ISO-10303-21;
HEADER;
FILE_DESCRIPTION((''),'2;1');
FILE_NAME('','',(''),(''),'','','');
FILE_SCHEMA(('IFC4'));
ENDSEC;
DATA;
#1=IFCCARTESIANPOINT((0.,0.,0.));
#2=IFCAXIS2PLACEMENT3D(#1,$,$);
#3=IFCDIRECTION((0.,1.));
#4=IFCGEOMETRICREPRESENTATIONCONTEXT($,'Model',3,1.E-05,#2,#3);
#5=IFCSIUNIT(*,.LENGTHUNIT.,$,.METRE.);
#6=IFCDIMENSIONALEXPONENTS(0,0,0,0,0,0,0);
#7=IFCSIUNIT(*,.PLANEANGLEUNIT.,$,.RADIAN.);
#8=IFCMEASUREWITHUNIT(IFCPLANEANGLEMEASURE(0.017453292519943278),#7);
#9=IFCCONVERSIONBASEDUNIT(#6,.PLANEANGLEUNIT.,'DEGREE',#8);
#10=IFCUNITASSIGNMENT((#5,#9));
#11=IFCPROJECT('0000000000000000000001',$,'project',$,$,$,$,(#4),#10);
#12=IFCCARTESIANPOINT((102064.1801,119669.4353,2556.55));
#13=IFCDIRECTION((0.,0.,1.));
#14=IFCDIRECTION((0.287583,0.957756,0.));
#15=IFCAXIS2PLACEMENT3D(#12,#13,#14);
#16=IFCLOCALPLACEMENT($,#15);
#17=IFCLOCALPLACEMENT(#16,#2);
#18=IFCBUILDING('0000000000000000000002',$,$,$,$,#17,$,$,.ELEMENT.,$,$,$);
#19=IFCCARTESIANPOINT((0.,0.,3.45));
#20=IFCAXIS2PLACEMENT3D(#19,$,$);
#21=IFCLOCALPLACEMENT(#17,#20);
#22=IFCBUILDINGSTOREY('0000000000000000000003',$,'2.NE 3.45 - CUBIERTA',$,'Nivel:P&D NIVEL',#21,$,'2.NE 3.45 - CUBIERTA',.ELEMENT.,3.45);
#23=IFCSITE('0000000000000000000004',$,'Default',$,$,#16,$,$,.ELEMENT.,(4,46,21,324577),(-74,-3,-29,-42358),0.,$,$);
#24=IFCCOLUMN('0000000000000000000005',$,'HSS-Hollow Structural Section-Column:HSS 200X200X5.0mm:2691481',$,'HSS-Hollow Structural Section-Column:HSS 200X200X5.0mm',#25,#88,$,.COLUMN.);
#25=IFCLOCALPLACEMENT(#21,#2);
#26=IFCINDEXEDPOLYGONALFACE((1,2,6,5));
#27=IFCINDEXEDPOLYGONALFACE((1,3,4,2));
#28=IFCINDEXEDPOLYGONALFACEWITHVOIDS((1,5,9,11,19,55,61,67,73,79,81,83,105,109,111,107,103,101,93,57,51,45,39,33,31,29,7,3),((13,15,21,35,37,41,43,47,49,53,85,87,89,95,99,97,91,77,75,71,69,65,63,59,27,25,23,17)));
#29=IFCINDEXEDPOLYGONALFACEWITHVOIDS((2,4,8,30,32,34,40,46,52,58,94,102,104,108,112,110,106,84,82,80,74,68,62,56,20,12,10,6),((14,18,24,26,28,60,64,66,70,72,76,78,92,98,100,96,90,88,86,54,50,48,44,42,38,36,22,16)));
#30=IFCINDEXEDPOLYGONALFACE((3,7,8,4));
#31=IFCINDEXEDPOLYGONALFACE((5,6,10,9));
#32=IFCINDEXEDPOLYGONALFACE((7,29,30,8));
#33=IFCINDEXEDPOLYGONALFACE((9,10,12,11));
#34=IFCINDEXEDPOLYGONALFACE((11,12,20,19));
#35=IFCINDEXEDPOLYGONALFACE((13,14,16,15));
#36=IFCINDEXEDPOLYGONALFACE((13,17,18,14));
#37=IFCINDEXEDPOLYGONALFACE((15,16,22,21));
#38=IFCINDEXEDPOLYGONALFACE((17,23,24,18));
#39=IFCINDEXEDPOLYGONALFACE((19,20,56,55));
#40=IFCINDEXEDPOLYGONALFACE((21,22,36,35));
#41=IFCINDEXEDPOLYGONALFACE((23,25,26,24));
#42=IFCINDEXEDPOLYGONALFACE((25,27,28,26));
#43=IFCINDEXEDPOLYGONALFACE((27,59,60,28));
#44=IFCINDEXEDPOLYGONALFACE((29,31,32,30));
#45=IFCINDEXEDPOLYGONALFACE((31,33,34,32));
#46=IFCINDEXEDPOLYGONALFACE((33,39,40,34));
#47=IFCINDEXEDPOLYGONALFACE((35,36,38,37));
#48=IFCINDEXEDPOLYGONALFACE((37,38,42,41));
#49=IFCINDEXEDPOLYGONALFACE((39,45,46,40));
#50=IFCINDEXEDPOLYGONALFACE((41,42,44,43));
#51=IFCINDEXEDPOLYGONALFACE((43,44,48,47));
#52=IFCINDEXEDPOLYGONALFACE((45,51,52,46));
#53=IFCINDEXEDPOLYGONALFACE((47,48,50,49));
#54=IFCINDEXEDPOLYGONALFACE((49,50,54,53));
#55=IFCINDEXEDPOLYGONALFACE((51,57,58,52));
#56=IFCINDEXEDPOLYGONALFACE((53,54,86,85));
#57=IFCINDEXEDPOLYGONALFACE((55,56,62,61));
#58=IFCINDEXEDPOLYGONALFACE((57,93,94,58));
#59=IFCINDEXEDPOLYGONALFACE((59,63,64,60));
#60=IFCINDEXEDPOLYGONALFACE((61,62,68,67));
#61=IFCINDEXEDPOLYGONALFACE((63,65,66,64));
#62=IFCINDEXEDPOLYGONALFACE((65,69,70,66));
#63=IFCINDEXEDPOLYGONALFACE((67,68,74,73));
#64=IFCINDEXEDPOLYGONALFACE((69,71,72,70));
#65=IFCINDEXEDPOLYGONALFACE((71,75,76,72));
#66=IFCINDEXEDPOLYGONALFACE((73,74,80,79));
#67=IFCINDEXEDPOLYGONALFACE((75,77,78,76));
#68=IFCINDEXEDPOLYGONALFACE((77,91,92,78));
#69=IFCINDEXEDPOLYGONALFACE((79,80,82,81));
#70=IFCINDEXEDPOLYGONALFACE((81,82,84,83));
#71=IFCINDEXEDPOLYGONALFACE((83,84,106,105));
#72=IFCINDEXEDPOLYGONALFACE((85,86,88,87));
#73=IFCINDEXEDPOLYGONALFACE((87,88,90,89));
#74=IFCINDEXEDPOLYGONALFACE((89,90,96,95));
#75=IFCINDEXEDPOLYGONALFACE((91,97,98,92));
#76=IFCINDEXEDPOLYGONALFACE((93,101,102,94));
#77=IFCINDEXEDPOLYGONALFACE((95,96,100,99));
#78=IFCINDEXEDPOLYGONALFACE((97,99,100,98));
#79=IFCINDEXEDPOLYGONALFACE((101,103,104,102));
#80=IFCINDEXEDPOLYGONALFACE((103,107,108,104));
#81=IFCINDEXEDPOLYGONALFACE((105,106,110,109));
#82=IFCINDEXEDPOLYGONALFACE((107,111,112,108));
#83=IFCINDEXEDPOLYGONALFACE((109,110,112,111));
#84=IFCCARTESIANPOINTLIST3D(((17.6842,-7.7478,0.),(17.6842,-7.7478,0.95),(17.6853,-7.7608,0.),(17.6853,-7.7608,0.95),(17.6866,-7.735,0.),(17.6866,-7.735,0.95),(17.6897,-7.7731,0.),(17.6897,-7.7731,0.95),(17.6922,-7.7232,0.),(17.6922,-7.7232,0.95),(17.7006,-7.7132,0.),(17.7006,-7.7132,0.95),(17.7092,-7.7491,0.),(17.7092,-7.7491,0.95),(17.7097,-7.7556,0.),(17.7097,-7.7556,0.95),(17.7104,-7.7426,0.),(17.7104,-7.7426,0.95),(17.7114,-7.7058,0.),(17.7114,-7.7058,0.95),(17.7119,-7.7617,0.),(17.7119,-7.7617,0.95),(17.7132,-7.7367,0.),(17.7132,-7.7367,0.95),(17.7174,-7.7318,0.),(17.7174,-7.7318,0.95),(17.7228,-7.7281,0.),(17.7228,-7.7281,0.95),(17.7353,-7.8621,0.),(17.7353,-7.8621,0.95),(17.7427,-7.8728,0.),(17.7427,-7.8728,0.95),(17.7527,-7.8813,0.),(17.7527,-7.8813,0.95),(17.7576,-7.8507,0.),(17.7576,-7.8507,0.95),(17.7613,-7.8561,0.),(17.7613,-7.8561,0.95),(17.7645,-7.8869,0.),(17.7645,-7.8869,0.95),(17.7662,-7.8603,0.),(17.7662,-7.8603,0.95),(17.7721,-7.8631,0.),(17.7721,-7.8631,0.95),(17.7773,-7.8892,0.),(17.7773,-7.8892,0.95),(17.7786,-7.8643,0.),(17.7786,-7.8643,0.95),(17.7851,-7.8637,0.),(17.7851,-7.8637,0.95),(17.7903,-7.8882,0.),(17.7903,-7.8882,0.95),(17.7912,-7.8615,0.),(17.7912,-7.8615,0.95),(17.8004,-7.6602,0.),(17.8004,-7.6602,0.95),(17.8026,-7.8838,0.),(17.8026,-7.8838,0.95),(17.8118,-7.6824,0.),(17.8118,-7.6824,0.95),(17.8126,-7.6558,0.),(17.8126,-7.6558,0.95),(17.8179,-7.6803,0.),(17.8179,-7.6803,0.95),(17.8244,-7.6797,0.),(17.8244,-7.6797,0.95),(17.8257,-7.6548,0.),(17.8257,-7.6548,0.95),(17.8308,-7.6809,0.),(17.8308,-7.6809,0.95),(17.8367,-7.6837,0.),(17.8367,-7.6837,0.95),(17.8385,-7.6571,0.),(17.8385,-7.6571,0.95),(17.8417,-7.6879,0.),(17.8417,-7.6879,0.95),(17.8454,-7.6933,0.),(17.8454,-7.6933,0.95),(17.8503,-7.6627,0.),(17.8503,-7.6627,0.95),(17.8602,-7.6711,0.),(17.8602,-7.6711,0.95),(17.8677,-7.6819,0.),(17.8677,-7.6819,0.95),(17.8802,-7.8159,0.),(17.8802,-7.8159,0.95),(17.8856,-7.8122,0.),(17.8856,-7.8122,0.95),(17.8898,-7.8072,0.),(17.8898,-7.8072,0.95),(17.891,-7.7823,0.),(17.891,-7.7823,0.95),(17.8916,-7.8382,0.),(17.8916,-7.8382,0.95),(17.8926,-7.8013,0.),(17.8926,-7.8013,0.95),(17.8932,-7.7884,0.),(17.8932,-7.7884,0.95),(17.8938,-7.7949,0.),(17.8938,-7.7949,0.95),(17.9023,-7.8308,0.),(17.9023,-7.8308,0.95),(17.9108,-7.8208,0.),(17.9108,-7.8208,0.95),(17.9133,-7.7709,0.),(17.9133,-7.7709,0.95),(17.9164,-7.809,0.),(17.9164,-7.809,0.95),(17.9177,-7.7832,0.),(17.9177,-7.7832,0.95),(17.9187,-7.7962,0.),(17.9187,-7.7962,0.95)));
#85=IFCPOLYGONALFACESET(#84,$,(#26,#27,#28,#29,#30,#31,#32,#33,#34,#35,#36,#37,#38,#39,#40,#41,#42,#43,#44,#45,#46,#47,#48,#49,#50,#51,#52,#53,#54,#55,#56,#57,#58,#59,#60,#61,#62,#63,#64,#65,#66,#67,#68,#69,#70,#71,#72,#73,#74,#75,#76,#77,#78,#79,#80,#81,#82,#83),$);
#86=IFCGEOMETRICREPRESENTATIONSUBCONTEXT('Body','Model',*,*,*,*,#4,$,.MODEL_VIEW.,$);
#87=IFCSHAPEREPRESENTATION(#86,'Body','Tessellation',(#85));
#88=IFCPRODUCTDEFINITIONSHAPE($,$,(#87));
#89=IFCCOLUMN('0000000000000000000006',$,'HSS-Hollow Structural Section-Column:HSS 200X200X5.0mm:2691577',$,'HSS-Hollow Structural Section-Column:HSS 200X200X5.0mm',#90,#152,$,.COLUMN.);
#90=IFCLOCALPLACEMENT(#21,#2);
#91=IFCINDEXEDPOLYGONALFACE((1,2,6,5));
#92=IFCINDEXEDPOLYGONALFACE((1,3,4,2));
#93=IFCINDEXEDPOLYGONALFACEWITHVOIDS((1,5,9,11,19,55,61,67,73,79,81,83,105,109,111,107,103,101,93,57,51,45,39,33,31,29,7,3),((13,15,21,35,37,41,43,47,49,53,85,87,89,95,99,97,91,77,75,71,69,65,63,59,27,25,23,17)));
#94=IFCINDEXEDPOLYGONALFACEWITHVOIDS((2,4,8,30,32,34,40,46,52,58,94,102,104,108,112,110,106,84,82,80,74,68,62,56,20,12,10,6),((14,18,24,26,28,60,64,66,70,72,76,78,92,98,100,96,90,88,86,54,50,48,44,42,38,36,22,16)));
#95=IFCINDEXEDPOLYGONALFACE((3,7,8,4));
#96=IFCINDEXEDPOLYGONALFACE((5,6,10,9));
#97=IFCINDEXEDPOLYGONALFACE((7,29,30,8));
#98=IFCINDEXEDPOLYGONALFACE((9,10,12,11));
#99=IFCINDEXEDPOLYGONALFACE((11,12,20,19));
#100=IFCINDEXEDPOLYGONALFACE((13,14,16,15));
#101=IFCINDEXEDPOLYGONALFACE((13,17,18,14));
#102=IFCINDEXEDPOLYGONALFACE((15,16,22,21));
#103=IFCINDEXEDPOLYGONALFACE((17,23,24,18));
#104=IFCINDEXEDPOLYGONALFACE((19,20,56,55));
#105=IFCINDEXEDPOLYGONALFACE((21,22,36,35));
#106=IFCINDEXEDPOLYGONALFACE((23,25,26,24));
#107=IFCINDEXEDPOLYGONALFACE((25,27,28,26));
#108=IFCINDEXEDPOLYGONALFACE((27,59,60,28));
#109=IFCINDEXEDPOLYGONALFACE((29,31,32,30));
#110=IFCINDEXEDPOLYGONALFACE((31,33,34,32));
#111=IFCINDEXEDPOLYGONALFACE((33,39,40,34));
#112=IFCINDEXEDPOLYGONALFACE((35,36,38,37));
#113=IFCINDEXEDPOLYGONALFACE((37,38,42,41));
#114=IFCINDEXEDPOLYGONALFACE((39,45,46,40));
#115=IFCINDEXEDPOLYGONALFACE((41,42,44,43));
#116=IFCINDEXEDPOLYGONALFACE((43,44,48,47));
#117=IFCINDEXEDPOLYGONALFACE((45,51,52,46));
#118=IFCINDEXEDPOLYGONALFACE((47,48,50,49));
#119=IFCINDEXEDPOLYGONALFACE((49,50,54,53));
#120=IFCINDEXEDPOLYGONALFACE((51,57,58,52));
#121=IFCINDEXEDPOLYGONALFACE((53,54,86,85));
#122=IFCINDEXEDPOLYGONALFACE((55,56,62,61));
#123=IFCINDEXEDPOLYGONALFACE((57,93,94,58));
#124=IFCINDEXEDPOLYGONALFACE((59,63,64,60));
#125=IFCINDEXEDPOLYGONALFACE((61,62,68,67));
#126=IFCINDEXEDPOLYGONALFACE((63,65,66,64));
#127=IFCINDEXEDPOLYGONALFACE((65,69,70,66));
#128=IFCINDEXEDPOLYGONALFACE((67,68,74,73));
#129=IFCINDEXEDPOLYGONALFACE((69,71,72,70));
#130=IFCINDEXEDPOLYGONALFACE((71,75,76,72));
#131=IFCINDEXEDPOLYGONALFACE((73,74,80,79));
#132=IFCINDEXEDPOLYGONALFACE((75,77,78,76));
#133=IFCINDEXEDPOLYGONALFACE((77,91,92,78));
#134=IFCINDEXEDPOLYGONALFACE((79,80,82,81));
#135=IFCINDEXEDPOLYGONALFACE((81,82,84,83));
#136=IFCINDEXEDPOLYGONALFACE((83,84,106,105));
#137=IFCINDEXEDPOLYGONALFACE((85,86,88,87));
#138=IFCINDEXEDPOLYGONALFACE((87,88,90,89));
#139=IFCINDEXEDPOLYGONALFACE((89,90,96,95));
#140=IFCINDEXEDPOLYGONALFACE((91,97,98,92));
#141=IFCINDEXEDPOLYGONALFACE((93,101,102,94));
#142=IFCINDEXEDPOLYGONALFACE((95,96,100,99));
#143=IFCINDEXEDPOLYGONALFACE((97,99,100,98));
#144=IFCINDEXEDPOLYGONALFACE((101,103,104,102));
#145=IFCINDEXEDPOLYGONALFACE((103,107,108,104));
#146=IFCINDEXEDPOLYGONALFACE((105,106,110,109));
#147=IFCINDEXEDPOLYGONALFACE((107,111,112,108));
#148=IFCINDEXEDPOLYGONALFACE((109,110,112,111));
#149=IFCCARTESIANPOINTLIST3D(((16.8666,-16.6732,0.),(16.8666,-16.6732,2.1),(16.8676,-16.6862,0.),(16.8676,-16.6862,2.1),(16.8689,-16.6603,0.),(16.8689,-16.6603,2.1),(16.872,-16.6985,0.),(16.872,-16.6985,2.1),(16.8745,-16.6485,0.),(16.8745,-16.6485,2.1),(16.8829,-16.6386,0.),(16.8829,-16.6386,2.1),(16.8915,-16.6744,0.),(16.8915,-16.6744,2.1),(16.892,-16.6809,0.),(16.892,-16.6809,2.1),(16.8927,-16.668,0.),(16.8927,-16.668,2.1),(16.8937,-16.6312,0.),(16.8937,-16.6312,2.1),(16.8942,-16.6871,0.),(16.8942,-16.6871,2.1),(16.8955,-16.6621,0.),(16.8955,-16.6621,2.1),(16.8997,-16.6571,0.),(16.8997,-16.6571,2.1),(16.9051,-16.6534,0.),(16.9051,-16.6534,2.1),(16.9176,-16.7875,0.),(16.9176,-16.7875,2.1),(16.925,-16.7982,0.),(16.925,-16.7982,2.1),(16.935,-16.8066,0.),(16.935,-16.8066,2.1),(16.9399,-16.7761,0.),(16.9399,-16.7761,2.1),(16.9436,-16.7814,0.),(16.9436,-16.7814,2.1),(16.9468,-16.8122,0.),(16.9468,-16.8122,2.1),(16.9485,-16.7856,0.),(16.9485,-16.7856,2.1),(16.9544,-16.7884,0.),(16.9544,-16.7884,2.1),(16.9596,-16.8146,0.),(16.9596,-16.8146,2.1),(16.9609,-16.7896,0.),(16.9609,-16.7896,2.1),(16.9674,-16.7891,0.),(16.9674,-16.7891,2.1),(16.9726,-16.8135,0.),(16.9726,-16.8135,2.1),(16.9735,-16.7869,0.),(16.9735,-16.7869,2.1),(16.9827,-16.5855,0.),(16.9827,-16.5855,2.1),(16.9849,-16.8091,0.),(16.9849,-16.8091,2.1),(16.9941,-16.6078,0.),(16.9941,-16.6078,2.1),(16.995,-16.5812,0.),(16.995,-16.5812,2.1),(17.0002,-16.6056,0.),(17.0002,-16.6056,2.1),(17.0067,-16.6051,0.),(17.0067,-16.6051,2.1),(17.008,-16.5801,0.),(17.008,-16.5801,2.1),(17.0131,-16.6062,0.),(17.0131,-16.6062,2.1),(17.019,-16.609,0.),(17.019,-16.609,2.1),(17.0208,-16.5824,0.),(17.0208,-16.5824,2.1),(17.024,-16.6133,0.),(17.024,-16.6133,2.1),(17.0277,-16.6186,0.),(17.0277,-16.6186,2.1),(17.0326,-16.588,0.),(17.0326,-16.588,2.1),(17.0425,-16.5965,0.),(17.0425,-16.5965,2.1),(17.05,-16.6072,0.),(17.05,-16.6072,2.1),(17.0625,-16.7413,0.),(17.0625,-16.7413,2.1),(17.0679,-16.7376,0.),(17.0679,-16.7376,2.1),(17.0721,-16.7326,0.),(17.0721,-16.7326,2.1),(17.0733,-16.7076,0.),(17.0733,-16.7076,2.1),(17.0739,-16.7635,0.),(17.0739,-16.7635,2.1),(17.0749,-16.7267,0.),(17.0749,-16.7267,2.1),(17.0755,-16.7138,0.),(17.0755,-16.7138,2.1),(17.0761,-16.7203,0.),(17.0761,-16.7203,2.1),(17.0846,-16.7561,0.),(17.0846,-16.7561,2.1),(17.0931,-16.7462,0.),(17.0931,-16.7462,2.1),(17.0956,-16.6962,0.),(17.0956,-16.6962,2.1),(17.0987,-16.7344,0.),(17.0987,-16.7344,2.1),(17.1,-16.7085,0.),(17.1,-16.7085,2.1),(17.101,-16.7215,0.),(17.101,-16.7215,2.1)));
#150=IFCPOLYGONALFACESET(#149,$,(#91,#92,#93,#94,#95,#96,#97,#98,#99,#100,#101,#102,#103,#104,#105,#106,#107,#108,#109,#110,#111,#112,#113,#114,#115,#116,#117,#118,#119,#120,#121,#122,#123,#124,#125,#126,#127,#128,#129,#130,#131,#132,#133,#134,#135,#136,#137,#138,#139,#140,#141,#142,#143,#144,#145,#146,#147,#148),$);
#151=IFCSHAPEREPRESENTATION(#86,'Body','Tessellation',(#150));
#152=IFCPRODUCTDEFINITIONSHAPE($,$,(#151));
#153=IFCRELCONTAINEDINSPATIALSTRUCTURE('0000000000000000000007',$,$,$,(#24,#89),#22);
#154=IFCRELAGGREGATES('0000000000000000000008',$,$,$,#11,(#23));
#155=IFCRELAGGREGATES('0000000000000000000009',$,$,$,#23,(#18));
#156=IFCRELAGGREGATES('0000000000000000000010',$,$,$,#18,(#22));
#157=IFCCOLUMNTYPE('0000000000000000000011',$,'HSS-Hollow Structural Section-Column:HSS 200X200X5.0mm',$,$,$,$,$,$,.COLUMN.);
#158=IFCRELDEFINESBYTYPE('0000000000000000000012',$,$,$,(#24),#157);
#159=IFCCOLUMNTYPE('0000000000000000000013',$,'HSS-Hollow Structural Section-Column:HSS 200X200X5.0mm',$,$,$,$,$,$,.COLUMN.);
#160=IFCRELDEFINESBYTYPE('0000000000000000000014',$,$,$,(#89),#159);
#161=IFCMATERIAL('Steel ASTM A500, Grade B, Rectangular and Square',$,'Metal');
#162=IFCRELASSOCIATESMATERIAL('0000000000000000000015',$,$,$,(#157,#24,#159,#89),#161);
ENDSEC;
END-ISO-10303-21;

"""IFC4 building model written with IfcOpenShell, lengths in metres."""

from ifc_helpers import new_model, entity, si_unit, converted_unit, direction, frame, origin, place, context, subcontext, project, spatial, line, arc, indexed_curve, outline, extrude, source, transform, mapped, material, type_object, type_shapes, element, save


model = new_model("IFC4")

# Units and contexts
model_context = context("Model", 3, precision=1e-05, world=origin(), true_north=direction((0.0, 1.0)))
body_context = subcontext(model_context, "Body", "Model", "MODEL_VIEW")
ifc_project = project(units=[si_unit("LENGTHUNIT", "METRE"), converted_unit("PLANEANGLEUNIT", "DEGREE", entity("IfcPlaneAngleMeasure", 0.017453292519943278), si_unit("PLANEANGLEUNIT", "RADIAN"), dimensions=[0, 0, 0, 0, 0, 0, 0])], contexts=[model_context])

# Site, building, storey
site_placement = place(None, frame((102064.1801, 119669.4353, 2556.55), z_axis=(0.0, 0.0, 1.0), x_axis=(0.287583, 0.957756, 0.0)))
site = spatial("IfcSite", under=ifc_project, at=site_placement, Name="Default", CompositionType="ELEMENT", RefLatitude=(4, 46, 21, 324577), RefLongitude=(-74, -3, -29, -42358), RefElevation=0.0)
building_placement = place(site_placement, origin())
building = spatial("IfcBuilding", under=site, at=building_placement, CompositionType="ELEMENT")
storey_placement = place(building_placement, frame((0.0, 0.0, 3.45)))
storey = spatial("IfcBuildingStorey", under=building, at=storey_placement, Name="2.NE 3.45 - CUBIERTA", ObjectType="Nivel:P&D NIVEL", LongName="2.NE 3.45 - CUBIERTA", CompositionType="ELEMENT", Elevation=3.45)

# Columns
ifc_material_1 = material(Name="Steel ASTM A500, Grade B, Rectangular and Square", Category="Metal")
column_type_1 = type_object("IfcColumnType", Name="HSS-Hollow Structural Section-Column:HSS 200X200X5.0mm", PredefinedType="COLUMN", material=ifc_material_1)
shared_shape_1 = source(origin(), body_context, "Body", "SweptSolid", [
    extrude(outline(indexed_curve([(-0.05, -0.1), (0.05, -0.1), (0.0854, -0.0854), (0.1, -0.05), (0.1, 0.05), (0.0854, 0.0854), (0.05, 0.1), (-0.05, 0.1), (-0.0854, 0.0854), (-0.1, 0.05), (-0.1, -0.05), (-0.0854, -0.0854)], segments=[line(1, 2), arc(2, 3, 4), line(4, 5), arc(5, 6, 7), line(7, 8), arc(8, 9, 10), line(10, 11), arc(11, 12, 1)], self_intersect=False), holes=[indexed_curve([(-0.05, -0.075), (-0.0677, -0.0677), (-0.075, -0.05), (-0.075, 0.05), (-0.0677, 0.0677), (-0.05, 0.075), (0.05, 0.075), (0.0677, 0.0677), (0.075, 0.05), (0.075, -0.05), (0.0677, -0.0677), (0.05, -0.075)], segments=[arc(1, 2, 3), line(3, 4), arc(4, 5, 6), line(6, 7), arc(7, 8, 9), line(9, 10), arc(10, 11, 12), line(12, 1)], self_intersect=False)]), frame((0.0, 0.0, 3.45), z_axis=(0.0, 0.0, 1.0), x_axis=(-1.0, 0.0, 0.0)), (0.0, 0.0, 1.0), 0.95),
])
type_shapes(column_type_1, [shared_shape_1])
column_placement = place(storey_placement, frame((17.8015, -7.772, -3.45), z_axis=(0.0, 0.0, 1.0), x_axis=(0.889869, 0.456217, 0.0)))
element("IfcColumn", 1, at=column_placement, inside=storey, type_object=column_type_1, material=ifc_material_1, Name="HSS-Hollow Structural Section-Column:HSS 200X200X5.0mm:2691481", ObjectType="HSS-Hollow Structural Section-Column:HSS 200X200X5.0mm", PredefinedType="COLUMN", context=body_context, shape_type="MappedRepresentation", body=[
    mapped(shared_shape_1, transform((0.0, 0.0, 0.0), scale=1.0)),
])
column_type_2 = type_object("IfcColumnType", Name="HSS-Hollow Structural Section-Column:HSS 200X200X5.0mm", PredefinedType="COLUMN", material=ifc_material_1)
shared_shape_2 = source(origin(), body_context, "Body", "SweptSolid", [
    extrude(outline(indexed_curve([(-0.05, -0.1), (0.05, -0.1), (0.0854, -0.0854), (0.1, -0.05), (0.1, 0.05), (0.0854, 0.0854), (0.05, 0.1), (-0.05, 0.1), (-0.0854, 0.0854), (-0.1, 0.05), (-0.1, -0.05), (-0.0854, -0.0854)], segments=[line(1, 2), arc(2, 3, 4), line(4, 5), arc(5, 6, 7), line(7, 8), arc(8, 9, 10), line(10, 11), arc(11, 12, 1)], self_intersect=False), holes=[indexed_curve([(-0.05, -0.075), (-0.0677, -0.0677), (-0.075, -0.05), (-0.075, 0.05), (-0.0677, 0.0677), (-0.05, 0.075), (0.05, 0.075), (0.0677, 0.0677), (0.075, 0.05), (0.075, -0.05), (0.0677, -0.0677), (0.05, -0.075)], segments=[arc(1, 2, 3), line(3, 4), arc(4, 5, 6), line(6, 7), arc(7, 8, 9), line(9, 10), arc(10, 11, 12), line(12, 1)], self_intersect=False)]), frame((0.0, 0.0, 3.45), z_axis=(0.0, 0.0, 1.0), x_axis=(-1.0, 0.0, 0.0)), (0.0, 0.0, 1.0), 2.1),
])
type_shapes(column_type_2, [shared_shape_2])
for number, where, z_axis, x_axis, name in (
    (2, (16.9838, -16.6973, -3.45), (0.0, 0.0, 1.0), (0.889869, 0.456217, 0.0), "HSS-Hollow Structural Section-Column:HSS 200X200X5.0mm:2691577"),
):
    element("IfcColumn", number, at=place(storey_placement, frame(where, z_axis=z_axis, x_axis=x_axis)), inside=storey, type_object=column_type_2, material=ifc_material_1, Name=name, ObjectType="HSS-Hollow Structural Section-Column:HSS 200X200X5.0mm", PredefinedType="COLUMN", context=body_context, shape_type="MappedRepresentation", body=[
        mapped(shared_shape_2, transform((0.0, 0.0, 0.0), scale=1.0)),
    ])

save(model, "model.ifc")
